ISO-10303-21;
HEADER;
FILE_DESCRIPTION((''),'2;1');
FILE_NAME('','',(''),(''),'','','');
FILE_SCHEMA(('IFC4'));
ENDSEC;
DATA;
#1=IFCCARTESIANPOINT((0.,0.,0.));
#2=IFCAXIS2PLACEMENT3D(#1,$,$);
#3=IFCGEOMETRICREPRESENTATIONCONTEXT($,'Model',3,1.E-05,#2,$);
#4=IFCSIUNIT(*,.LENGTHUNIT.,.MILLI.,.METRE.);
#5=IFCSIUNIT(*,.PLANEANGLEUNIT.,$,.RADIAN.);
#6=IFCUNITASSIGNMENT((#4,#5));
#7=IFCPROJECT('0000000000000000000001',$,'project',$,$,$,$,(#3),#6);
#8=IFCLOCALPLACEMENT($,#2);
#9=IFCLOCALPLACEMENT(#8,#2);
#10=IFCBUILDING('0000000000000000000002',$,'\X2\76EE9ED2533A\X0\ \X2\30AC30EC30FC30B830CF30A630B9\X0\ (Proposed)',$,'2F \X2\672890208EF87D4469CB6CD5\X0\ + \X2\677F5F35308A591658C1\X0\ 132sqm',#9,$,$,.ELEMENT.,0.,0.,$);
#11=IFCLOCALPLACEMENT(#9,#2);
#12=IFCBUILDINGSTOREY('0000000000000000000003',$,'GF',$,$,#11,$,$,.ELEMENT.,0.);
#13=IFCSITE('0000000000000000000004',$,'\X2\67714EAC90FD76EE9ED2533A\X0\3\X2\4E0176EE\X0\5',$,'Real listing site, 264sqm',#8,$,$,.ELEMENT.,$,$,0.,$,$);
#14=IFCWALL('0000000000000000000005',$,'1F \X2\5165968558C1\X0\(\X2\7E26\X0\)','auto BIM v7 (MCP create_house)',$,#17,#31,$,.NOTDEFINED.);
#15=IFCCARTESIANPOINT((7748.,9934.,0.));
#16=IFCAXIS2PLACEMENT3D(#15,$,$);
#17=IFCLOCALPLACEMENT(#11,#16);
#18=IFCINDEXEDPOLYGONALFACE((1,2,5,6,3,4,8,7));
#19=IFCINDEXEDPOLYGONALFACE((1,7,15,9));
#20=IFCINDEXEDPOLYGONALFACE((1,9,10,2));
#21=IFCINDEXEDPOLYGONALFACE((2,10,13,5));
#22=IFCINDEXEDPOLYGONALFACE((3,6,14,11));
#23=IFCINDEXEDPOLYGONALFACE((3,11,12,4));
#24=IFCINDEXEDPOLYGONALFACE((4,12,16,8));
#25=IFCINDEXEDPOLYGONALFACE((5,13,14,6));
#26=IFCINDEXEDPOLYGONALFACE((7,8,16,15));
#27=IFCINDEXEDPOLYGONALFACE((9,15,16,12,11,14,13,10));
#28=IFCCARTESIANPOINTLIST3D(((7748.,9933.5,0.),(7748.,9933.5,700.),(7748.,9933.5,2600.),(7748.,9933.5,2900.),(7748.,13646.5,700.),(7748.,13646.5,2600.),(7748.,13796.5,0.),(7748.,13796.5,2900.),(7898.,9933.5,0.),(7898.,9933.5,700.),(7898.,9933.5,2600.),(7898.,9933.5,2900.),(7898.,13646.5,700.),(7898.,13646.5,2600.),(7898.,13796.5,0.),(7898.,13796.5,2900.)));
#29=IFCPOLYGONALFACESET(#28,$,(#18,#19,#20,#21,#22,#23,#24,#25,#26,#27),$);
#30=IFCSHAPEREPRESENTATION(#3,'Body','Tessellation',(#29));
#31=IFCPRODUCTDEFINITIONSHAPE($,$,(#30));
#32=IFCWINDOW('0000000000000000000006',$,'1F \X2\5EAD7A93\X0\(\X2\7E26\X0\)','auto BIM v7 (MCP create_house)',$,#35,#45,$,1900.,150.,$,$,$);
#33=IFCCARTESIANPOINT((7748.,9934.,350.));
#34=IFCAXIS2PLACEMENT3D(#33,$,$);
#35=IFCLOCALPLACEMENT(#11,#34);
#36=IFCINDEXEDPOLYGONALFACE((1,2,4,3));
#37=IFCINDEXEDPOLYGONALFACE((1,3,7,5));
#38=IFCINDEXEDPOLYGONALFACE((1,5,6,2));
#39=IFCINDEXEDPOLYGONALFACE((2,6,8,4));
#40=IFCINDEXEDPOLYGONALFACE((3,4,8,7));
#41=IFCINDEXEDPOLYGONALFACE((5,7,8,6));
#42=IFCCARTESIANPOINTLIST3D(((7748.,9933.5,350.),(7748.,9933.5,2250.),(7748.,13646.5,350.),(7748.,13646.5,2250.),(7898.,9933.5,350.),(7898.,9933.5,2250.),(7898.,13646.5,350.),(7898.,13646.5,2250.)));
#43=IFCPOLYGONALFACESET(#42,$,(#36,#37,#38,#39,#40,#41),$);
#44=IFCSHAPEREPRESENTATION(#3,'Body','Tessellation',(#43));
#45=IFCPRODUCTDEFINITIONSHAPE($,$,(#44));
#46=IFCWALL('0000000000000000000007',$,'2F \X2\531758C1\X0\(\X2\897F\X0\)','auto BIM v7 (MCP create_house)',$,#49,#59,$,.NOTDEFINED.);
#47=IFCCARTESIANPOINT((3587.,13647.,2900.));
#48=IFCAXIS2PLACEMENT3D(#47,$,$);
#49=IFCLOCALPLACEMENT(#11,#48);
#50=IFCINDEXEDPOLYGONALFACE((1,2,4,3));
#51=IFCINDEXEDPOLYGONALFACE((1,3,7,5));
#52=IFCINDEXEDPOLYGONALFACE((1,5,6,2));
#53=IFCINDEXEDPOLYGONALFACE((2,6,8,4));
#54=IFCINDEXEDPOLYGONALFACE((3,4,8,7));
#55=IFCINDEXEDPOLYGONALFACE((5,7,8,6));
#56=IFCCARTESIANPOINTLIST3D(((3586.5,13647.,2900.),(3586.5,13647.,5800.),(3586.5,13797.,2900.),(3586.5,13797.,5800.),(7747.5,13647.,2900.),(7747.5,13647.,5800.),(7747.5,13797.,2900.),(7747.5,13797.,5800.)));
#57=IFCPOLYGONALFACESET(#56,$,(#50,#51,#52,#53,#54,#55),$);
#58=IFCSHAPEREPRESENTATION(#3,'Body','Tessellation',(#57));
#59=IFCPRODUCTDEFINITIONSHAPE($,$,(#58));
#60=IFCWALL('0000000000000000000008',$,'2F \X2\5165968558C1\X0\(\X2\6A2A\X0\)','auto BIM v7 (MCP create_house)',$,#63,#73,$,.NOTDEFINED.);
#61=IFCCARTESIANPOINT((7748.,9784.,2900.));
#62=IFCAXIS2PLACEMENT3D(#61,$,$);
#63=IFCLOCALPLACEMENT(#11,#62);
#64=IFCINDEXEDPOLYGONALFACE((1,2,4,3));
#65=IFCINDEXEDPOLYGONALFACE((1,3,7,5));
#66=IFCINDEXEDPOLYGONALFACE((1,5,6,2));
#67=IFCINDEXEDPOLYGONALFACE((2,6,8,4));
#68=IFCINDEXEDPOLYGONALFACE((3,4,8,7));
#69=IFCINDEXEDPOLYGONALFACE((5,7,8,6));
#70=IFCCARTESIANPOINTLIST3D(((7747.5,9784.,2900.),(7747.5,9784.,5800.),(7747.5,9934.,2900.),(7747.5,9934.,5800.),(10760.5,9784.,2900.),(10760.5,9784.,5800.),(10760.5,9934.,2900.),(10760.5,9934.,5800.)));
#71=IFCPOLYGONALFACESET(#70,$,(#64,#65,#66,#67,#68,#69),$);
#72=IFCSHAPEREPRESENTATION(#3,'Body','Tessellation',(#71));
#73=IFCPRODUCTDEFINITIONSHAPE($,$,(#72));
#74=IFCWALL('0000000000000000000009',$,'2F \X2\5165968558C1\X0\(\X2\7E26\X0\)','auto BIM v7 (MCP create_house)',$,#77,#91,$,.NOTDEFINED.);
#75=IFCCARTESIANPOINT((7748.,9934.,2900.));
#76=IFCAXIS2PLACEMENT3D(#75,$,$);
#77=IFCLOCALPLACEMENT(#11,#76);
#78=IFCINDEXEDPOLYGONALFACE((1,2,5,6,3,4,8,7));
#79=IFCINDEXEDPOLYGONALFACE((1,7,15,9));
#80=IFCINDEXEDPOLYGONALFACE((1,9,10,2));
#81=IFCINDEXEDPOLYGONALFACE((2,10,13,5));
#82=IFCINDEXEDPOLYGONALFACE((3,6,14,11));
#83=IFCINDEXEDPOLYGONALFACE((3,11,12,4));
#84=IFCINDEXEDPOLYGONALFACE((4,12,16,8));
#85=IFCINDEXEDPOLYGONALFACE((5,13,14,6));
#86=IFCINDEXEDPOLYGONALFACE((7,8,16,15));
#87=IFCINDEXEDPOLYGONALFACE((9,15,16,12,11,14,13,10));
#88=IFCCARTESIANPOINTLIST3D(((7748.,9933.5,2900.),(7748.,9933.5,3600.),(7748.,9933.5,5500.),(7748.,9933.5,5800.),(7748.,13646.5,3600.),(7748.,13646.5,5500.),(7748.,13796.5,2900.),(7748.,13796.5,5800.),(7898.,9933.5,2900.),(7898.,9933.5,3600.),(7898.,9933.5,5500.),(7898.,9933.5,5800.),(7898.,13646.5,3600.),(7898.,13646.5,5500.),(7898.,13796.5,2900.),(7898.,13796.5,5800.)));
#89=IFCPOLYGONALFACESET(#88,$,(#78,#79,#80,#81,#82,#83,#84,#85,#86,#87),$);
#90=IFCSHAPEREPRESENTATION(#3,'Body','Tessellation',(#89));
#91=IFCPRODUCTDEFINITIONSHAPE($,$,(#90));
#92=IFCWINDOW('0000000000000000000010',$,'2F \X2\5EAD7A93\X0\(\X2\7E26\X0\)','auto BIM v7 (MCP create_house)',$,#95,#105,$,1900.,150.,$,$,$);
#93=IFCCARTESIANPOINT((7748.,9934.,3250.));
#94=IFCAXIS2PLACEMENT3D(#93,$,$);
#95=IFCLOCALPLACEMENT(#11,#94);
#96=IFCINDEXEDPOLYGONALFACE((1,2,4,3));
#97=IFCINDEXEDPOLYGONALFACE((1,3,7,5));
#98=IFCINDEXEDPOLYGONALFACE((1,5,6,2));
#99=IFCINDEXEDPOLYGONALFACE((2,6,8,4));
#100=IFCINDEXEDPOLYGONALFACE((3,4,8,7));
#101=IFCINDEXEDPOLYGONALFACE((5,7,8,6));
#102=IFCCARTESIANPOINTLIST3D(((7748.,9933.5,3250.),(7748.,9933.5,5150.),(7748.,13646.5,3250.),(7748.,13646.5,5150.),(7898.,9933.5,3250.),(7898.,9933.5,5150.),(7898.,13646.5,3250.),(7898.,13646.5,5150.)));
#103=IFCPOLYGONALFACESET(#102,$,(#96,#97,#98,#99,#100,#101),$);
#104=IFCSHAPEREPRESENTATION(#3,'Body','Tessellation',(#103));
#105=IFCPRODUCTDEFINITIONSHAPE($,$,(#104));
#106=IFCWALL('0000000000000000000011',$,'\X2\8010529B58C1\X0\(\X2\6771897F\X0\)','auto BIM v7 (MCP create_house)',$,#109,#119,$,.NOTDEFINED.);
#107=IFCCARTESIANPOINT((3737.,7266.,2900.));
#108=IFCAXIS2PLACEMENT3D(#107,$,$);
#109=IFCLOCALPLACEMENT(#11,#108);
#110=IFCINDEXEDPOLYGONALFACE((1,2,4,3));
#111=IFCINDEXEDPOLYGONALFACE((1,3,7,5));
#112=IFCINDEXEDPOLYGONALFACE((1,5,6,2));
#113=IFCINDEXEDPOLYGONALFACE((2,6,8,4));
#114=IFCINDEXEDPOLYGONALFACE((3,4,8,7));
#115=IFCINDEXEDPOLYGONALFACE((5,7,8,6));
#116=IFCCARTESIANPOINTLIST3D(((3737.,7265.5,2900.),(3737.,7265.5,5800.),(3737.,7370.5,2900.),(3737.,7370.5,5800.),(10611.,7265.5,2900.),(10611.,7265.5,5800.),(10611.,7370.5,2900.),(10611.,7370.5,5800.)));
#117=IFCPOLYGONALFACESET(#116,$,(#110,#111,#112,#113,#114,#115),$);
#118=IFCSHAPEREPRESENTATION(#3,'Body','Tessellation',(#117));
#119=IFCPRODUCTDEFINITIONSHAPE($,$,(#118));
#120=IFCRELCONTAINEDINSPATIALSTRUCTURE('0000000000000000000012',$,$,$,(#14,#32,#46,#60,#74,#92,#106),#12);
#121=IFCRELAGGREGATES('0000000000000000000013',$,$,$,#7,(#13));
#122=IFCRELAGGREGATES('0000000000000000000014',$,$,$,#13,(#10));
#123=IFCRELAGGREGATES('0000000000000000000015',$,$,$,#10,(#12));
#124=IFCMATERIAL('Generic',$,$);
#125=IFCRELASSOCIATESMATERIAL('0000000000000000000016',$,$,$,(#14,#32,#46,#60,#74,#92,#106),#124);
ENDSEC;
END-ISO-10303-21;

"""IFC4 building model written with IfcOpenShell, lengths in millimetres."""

from ifc_helpers import new_model, si_unit, frame, frame_2d, origin, place, context, project, spatial, rectangle, extrude, material, element, fill, save


model = new_model("IFC4")

# Units and contexts
model_context = context("Model", 3, precision=1e-05, world=origin())
ifc_project = project(units=[si_unit("LENGTHUNIT", "METRE", prefix="MILLI"), si_unit("PLANEANGLEUNIT", "RADIAN")], contexts=[model_context])

# Site, building, storey
site_placement = place(None, origin())
site = spatial("IfcSite", under=ifc_project, at=site_placement, Name="東京都目黒区3丁目5", ObjectType="Real listing site, 264sqm", CompositionType="ELEMENT", RefElevation=0.0)
building_placement = place(site_placement, origin())
building = spatial("IfcBuilding", under=site, at=building_placement, Name="目黒区 ガレージハウス (Proposed)", ObjectType="2F 木造軸組構法 + 板張り外壁 132sqm", CompositionType="ELEMENT", ElevationOfRefHeight=0.0, ElevationOfTerrain=0.0)
storey_placement = place(building_placement, origin())
storey = spatial("IfcBuildingStorey", under=building, at=storey_placement, Name="GF", CompositionType="ELEMENT", Elevation=0.0)

# Shared definitions
ifc_material = material(Name="Generic")

# Wall, opening, window
wall_1_placement = place(storey_placement, frame((7748.0, 9934.0, 0.0)))
wall_1 = element("IfcWall", 1, at=wall_1_placement, inside=storey, material=ifc_material, Name="1F 入隅壁(縦)", Description="auto BIM v7 (MCP create_house)", PredefinedType="NOTDEFINED", context=model_context, shape_type="SweptSolid", body=[
    extrude(rectangle(XDim=150.0, YDim=3863.0, at=frame_2d((75.0, 1931.0))), frame((7748.0, 9934.0, 0.0)), (0.0, 0.0, 1.0), 2900.0),
])
opening_1_placement = place(storey_placement, frame((7748.0, 9934.0, 350.0)))
opening_1 = element("IfcOpeningElement", 2, at=opening_1_placement, cuts=wall_1, PredefinedType="NOTDEFINED", context=model_context, shape_type="SweptSolid", body=[
    extrude(rectangle(XDim=150.0, YDim=3713.0, at=frame_2d((75.0, 1856.0))), frame((7748.0, 9934.0, 350.0)), (0.0, 0.0, 1.0), 1900.0),
])
window_1_placement = place(storey_placement, frame((7748.0, 9934.0, 350.0)))
window_1 = element("IfcWindow", 3, at=window_1_placement, inside=storey, material=ifc_material, Name="1F 庭窓(縦)", Description="auto BIM v7 (MCP create_house)", OverallHeight=1900.0, OverallWidth=150.0, context=model_context, shape_type="SweptSolid", body=[
    extrude(rectangle(XDim=150.0, YDim=3713.0, at=frame_2d((75.0, 1856.0))), frame((7748.0, 9934.0, 350.0)), (0.0, 0.0, 1.0), 1900.0),
])
fill(opening_1, window_1)

# Walls
wall_2_placement = place(storey_placement, frame((3587.0, 13647.0, 2900.0)))
element("IfcWall", 4, at=wall_2_placement, inside=storey, material=ifc_material, Name="2F 北壁(西)", Description="auto BIM v7 (MCP create_house)", PredefinedType="NOTDEFINED", context=model_context, shape_type="SweptSolid", body=[
    extrude(rectangle(XDim=4161.0, YDim=150.0, at=frame_2d((2080.0, 75.0))), frame((3587.0, 13647.0, 2900.0)), (0.0, 0.0, 1.0), 2900.0),
])
wall_3_placement = place(storey_placement, frame((7748.0, 9784.0, 2900.0)))
element("IfcWall", 5, at=wall_3_placement, inside=storey, material=ifc_material, Name="2F 入隅壁(横)", Description="auto BIM v7 (MCP create_house)", PredefinedType="NOTDEFINED", context=model_context, shape_type="SweptSolid", body=[
    extrude(rectangle(XDim=3013.0, YDim=150.0, at=frame_2d((1506.0, 75.0))), frame((7748.0, 9784.0, 2900.0)), (0.0, 0.0, 1.0), 2900.0),
])

# Wall, opening, window
wall_4_placement = place(storey_placement, frame((7748.0, 9934.0, 2900.0)))
wall_4 = element("IfcWall", 6, at=wall_4_placement, inside=storey, material=ifc_material, Name="2F 入隅壁(縦)", Description="auto BIM v7 (MCP create_house)", PredefinedType="NOTDEFINED", context=model_context, shape_type="SweptSolid", body=[
    extrude(rectangle(XDim=150.0, YDim=3863.0, at=frame_2d((75.0, 1931.0))), frame((7748.0, 9934.0, 2900.0)), (0.0, 0.0, 1.0), 2900.0),
])
opening_2_placement = place(storey_placement, frame((7748.0, 9934.0, 3250.0)))
opening_2 = element("IfcOpeningElement", 7, at=opening_2_placement, cuts=wall_4, PredefinedType="NOTDEFINED", context=model_context, shape_type="SweptSolid", body=[
    extrude(rectangle(XDim=150.0, YDim=3713.0, at=frame_2d((75.0, 1856.0))), frame((7748.0, 9934.0, 3250.0)), (0.0, 0.0, 1.0), 1900.0),
])
window_2_placement = place(storey_placement, frame((7748.0, 9934.0, 3250.0)))
window_2 = element("IfcWindow", 8, at=window_2_placement, inside=storey, material=ifc_material, Name="2F 庭窓(縦)", Description="auto BIM v7 (MCP create_house)", OverallHeight=1900.0, OverallWidth=150.0, context=model_context, shape_type="SweptSolid", body=[
    extrude(rectangle(XDim=150.0, YDim=3713.0, at=frame_2d((75.0, 1856.0))), frame((7748.0, 9934.0, 3250.0)), (0.0, 0.0, 1.0), 1900.0),
])
fill(opening_2, window_2)

# Wall
wall_5_placement = place(storey_placement, frame((3737.0, 7266.0, 2900.0)))
element("IfcWall", 9, at=wall_5_placement, inside=storey, material=ifc_material, Name="耐力壁(東西)", Description="auto BIM v7 (MCP create_house)", PredefinedType="NOTDEFINED", context=model_context, shape_type="SweptSolid", body=[
    extrude(rectangle(XDim=6874.0, YDim=105.0, at=frame_2d((3437.0, 52.0))), frame((3737.0, 7266.0, 2900.0)), (0.0, 0.0, 1.0), 2900.0),
])

save(model, "model.ifc")
